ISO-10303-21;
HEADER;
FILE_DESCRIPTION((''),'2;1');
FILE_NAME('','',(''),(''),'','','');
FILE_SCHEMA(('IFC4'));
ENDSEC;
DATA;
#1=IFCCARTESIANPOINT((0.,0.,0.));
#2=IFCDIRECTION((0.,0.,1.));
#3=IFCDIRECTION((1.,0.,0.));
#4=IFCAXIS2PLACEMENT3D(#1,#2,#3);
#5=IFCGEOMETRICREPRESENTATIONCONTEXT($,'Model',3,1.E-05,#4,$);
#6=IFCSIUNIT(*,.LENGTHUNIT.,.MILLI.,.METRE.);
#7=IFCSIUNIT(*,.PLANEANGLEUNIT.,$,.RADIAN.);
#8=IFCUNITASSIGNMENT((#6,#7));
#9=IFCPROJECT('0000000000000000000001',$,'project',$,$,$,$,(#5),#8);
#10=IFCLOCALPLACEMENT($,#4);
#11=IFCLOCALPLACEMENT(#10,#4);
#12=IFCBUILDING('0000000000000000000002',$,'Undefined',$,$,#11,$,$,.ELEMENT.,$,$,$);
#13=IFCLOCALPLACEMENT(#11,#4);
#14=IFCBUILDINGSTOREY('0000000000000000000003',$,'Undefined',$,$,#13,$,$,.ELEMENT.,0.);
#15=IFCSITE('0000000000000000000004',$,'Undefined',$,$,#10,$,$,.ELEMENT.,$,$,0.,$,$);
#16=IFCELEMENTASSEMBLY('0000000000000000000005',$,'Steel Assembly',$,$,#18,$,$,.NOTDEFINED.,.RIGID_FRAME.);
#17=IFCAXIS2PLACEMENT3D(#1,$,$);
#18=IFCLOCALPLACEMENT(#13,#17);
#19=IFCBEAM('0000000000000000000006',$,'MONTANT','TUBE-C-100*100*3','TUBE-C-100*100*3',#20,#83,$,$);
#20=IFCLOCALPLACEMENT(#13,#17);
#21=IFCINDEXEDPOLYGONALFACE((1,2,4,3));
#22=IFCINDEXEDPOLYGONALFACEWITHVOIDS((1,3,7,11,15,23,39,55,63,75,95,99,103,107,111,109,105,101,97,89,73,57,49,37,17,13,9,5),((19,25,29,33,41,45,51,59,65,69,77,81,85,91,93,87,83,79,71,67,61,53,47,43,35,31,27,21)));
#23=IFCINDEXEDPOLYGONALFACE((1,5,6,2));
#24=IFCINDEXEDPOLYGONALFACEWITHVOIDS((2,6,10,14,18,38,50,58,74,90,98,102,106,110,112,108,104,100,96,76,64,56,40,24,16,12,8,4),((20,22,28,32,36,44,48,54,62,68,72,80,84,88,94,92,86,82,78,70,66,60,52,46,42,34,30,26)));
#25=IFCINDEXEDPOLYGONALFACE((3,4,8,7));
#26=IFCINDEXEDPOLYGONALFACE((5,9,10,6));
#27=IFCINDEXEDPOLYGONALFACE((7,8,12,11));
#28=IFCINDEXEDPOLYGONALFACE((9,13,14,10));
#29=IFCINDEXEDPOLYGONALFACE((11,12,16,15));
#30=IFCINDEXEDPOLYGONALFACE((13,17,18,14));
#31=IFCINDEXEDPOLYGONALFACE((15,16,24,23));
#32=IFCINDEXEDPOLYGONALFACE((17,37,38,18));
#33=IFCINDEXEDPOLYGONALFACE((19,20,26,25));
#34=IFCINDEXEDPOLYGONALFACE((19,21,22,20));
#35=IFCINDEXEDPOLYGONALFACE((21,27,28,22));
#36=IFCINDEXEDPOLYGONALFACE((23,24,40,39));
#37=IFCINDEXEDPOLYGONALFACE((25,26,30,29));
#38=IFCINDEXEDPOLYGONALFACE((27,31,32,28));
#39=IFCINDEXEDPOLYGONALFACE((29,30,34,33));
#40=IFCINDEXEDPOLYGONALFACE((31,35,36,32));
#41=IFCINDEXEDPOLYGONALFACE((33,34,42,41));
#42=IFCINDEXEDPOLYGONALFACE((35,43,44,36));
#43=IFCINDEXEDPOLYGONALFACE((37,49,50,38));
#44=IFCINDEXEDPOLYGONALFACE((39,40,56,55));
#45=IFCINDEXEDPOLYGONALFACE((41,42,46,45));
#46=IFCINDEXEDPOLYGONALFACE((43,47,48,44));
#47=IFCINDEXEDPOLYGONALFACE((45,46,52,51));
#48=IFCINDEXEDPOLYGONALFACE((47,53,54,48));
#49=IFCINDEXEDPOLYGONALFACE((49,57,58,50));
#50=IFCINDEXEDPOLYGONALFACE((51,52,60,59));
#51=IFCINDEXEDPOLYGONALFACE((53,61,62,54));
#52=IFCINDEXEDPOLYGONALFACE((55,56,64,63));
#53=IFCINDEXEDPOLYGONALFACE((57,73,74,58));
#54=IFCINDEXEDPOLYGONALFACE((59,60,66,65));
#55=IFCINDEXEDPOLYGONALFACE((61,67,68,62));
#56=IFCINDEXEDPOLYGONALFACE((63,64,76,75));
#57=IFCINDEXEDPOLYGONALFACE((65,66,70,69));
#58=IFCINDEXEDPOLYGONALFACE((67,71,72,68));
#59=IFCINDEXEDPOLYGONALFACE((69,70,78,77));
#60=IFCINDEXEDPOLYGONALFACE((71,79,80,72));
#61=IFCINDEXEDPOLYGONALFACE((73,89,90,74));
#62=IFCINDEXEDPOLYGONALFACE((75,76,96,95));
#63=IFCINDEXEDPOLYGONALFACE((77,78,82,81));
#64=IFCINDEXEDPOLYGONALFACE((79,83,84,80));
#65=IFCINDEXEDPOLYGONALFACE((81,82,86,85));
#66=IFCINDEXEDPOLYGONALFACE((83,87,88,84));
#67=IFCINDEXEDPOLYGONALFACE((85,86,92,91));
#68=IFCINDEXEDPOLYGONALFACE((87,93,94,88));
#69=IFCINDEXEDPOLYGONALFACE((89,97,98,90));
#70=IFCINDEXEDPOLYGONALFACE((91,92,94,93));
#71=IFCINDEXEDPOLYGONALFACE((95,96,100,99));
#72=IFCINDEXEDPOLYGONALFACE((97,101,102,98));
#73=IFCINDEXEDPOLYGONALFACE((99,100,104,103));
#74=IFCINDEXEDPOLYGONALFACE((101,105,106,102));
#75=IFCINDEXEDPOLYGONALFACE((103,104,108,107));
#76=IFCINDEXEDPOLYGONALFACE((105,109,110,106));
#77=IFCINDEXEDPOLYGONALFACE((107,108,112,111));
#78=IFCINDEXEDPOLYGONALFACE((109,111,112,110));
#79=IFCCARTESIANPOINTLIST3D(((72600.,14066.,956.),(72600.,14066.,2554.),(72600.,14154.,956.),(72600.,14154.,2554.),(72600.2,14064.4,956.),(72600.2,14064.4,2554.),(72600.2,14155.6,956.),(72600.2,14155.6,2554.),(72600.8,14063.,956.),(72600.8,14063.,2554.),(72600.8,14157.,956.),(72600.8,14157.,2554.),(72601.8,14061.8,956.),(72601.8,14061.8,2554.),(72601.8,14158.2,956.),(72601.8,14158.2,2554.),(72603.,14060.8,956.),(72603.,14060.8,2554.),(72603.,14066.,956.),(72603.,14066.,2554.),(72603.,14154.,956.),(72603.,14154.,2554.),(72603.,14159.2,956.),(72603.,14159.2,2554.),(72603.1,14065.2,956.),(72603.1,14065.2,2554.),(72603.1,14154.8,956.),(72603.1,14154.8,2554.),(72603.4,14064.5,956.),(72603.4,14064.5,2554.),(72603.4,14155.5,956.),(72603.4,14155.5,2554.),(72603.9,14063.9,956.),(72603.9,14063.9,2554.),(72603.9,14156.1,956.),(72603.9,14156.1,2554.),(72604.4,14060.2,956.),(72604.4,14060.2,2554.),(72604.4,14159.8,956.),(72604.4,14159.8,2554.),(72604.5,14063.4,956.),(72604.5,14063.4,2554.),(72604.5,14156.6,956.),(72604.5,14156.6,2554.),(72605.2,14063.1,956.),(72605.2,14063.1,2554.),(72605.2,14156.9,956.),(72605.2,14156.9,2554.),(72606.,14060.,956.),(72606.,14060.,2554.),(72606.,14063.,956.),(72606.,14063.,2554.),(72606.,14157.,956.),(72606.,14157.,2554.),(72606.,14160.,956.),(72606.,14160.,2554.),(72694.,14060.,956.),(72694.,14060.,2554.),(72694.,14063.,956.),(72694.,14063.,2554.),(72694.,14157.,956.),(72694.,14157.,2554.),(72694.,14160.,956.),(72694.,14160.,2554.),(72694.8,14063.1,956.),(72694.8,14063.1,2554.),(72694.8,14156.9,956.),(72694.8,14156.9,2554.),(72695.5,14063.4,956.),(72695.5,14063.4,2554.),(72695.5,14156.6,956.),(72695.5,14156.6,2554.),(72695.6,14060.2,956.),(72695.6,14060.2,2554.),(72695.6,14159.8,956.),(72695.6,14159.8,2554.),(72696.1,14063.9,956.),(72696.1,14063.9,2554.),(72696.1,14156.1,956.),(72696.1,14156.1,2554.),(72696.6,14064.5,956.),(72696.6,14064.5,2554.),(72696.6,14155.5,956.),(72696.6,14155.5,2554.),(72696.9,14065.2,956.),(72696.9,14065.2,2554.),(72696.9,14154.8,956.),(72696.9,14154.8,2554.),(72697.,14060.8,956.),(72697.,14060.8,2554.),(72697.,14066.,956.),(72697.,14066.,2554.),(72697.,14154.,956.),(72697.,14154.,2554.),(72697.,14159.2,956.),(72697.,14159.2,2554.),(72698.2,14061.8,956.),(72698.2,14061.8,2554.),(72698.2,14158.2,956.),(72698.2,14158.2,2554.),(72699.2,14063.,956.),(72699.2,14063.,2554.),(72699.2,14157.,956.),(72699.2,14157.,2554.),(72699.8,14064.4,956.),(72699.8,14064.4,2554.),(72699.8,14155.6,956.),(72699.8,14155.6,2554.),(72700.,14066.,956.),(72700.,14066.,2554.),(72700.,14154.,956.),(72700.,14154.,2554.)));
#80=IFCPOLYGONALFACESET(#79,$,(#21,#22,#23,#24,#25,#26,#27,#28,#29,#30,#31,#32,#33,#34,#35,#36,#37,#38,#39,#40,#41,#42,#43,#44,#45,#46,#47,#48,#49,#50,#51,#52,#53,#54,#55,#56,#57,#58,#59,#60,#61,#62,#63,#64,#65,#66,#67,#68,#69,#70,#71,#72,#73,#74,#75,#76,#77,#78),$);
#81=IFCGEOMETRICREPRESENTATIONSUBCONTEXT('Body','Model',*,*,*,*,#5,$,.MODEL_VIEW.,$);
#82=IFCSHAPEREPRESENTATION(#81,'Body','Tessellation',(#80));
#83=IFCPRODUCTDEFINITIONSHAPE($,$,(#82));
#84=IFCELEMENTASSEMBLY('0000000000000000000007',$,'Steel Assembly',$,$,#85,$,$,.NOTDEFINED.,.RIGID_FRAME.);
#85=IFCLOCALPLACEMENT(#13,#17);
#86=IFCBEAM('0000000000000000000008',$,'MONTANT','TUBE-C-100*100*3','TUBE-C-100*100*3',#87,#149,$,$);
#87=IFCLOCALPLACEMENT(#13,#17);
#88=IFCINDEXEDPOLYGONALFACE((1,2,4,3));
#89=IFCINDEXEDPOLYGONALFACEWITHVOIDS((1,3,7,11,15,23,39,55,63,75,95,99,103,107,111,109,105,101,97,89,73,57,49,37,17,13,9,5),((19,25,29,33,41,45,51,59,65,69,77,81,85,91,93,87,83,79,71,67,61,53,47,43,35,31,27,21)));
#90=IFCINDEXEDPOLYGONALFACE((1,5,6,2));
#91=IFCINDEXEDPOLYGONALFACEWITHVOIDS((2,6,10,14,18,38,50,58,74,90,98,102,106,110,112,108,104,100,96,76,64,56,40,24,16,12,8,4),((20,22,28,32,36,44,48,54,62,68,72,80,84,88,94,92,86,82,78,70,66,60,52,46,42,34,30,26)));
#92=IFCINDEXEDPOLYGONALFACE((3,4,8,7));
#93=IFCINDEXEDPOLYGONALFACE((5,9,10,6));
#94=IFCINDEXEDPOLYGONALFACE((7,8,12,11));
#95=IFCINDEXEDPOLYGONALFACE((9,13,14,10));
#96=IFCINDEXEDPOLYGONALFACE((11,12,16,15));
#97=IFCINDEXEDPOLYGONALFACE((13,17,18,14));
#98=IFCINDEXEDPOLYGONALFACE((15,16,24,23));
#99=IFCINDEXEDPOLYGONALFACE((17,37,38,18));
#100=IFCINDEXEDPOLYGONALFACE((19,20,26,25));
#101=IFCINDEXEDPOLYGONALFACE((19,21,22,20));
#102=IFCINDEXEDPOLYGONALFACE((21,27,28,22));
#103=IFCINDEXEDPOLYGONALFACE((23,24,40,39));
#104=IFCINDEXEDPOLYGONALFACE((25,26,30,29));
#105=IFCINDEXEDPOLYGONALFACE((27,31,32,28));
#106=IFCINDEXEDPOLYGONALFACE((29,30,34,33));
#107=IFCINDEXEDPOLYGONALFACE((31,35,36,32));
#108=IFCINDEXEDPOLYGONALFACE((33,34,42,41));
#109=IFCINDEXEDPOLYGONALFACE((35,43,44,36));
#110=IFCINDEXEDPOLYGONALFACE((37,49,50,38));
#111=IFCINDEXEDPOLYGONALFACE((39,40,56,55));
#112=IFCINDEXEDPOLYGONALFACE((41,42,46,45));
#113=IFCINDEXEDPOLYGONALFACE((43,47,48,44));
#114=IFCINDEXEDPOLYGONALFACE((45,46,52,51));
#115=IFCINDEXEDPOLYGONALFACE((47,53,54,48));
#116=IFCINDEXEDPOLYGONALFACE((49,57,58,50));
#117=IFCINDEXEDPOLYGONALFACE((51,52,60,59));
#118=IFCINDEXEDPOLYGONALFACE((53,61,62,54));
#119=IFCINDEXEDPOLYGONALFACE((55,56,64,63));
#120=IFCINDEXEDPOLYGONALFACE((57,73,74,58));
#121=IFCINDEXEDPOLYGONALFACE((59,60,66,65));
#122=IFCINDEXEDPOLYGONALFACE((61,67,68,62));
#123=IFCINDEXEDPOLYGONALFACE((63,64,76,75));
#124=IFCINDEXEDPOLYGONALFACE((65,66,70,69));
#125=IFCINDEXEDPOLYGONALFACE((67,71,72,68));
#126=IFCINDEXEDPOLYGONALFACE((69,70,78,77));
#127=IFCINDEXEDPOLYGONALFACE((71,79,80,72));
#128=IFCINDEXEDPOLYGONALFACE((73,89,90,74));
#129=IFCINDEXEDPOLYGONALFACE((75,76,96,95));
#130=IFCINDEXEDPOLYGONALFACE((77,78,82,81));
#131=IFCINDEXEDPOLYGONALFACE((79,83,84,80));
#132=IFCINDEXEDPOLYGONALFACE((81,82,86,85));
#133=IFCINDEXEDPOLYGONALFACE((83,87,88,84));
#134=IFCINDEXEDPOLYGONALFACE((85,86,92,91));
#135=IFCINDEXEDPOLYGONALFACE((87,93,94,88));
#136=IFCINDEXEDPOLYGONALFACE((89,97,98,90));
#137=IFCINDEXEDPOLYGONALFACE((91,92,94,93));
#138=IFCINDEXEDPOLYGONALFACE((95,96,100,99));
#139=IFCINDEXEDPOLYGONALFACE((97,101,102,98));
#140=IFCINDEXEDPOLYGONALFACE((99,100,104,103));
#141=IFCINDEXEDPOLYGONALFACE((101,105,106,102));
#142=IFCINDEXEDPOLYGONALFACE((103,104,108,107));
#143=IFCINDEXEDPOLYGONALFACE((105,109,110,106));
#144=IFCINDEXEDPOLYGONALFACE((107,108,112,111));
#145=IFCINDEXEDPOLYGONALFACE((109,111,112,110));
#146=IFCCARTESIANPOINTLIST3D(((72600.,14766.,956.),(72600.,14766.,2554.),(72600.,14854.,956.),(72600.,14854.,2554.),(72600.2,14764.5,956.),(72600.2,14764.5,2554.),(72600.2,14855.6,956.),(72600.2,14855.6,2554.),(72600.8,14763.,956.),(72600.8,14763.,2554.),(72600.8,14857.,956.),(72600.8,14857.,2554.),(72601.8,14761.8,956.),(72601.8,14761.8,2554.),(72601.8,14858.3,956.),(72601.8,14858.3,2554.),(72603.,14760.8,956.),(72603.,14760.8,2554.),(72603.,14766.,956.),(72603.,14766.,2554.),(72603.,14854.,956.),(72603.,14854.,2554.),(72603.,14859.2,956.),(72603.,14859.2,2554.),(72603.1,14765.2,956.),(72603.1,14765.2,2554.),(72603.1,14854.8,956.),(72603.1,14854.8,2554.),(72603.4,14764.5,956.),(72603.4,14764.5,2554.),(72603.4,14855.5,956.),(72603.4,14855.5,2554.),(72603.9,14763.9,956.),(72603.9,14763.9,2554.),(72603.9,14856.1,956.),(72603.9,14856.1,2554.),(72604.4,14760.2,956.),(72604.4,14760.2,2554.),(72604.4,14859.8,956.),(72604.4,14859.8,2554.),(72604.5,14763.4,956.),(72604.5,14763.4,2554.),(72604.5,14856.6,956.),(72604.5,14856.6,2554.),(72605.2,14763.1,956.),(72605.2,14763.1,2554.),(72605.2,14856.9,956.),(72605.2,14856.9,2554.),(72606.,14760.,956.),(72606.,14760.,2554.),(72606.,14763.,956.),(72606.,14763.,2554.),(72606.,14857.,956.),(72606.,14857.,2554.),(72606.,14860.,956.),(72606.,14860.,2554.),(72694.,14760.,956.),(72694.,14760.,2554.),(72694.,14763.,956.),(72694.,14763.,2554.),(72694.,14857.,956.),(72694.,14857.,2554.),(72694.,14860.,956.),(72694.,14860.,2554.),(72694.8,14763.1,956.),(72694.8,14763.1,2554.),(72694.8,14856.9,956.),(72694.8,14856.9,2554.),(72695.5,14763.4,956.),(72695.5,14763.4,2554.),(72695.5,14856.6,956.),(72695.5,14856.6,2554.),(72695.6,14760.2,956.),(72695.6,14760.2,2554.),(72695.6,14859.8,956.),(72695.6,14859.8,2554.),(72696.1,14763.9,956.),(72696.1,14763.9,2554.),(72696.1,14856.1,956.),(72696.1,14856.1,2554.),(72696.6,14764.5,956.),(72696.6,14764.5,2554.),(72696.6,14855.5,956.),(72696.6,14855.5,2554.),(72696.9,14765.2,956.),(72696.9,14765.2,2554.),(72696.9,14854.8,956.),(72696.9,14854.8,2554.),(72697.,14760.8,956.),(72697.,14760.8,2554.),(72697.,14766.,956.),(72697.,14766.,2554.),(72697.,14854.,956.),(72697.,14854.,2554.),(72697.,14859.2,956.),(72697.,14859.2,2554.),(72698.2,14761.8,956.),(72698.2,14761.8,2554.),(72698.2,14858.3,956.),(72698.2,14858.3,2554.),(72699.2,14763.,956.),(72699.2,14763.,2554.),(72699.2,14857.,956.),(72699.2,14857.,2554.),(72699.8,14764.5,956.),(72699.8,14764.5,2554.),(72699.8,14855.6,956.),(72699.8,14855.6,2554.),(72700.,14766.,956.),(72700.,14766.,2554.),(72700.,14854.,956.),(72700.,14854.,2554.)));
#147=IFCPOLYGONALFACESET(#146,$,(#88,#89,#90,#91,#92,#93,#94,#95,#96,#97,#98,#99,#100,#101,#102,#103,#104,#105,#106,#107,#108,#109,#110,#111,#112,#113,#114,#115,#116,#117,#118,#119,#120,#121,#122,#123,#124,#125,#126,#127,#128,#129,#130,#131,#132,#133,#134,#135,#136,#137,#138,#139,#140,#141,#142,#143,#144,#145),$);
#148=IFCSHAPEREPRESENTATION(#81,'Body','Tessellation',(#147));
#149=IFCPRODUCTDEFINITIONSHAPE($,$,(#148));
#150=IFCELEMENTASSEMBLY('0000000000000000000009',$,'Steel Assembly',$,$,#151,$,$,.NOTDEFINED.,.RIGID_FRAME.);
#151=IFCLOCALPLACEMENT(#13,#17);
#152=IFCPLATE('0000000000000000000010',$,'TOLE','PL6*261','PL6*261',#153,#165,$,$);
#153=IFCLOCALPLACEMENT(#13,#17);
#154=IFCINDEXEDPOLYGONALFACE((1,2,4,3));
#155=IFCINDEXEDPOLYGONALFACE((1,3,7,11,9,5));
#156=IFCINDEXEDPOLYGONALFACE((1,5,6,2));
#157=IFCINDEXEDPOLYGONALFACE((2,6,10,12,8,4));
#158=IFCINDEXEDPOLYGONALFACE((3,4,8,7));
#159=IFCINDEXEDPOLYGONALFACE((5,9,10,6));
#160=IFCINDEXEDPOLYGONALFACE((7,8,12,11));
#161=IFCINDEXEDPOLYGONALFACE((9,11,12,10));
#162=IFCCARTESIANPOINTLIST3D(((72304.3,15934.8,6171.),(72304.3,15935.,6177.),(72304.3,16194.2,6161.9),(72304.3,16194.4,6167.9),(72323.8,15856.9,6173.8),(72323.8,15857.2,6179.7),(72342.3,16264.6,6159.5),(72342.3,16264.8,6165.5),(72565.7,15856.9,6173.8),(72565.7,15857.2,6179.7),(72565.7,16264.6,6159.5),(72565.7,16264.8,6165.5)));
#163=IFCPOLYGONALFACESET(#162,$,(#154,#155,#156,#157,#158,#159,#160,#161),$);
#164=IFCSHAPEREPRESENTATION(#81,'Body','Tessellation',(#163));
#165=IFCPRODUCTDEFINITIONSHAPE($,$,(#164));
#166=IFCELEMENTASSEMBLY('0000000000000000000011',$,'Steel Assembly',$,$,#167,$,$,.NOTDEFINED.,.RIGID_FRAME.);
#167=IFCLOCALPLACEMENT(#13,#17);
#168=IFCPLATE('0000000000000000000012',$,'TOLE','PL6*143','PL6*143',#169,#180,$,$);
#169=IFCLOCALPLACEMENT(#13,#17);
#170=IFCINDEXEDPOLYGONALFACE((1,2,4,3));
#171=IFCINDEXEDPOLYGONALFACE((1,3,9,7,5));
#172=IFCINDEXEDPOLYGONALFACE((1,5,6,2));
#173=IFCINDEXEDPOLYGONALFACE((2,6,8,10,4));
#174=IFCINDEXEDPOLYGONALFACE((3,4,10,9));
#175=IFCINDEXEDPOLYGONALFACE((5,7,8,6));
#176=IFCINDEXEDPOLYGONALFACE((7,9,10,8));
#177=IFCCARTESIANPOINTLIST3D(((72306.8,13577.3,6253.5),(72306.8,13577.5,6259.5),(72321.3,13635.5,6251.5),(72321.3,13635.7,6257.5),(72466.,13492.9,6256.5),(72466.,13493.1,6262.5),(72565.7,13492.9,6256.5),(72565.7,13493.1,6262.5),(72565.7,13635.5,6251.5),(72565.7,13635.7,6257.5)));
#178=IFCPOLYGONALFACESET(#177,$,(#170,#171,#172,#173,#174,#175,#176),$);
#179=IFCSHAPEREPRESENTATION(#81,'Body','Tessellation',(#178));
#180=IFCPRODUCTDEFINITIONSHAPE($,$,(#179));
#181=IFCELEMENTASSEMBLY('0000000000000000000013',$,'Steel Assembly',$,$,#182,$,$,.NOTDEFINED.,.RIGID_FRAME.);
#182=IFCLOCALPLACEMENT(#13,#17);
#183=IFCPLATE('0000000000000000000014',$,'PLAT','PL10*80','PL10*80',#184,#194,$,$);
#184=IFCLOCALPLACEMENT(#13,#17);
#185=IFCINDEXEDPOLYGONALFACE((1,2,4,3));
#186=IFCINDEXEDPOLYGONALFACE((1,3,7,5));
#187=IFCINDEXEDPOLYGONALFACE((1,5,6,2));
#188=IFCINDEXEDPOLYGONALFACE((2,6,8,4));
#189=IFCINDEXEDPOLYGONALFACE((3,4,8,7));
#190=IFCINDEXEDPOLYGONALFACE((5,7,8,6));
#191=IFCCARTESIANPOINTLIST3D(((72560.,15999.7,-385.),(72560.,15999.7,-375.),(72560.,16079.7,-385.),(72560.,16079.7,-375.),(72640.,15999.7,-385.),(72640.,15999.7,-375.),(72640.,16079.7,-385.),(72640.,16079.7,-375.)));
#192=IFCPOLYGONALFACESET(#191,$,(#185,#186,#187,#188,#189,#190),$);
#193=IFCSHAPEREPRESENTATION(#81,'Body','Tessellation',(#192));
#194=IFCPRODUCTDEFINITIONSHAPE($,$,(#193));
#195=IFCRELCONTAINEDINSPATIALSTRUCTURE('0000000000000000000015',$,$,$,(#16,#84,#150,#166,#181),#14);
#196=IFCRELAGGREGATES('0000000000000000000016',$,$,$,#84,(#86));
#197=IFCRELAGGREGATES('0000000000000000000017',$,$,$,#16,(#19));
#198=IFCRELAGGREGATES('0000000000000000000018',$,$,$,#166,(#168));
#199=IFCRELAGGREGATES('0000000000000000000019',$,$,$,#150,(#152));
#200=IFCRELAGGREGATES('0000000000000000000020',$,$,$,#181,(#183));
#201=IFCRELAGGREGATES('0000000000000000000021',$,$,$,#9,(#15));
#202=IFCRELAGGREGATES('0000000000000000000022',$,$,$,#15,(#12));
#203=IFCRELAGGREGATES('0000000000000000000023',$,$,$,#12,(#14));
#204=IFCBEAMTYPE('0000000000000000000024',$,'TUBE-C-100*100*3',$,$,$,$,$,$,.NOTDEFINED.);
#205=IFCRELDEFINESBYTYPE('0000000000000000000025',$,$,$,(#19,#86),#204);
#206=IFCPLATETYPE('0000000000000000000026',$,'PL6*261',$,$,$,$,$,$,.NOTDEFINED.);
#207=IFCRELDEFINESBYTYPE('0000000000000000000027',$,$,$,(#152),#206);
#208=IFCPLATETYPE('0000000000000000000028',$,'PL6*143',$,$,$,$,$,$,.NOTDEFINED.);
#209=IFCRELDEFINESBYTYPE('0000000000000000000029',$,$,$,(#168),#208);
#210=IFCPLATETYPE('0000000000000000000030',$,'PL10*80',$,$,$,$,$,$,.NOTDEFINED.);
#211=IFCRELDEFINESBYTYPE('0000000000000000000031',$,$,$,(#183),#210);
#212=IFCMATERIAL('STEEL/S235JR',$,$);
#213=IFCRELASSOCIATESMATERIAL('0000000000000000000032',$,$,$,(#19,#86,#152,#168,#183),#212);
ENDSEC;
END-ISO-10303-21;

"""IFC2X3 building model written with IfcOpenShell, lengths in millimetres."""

from ifc_helpers import new_model, si_unit, frame, origin_with_axes, origin_2d_with_axis, place, context, subcontext, project, spatial, polyline, hollow_rectangle, outline, extrude, clip, halfspace, material, type_object, element, aggregate, save


model = new_model("IFC2X3")

# Units and contexts
model_context = context("Model", 3, precision=1e-05, world=origin_with_axes())
body_context = subcontext(model_context, "Body", "Model", "MODEL_VIEW")
ifc_project = project(units=[si_unit("LENGTHUNIT", "METRE", prefix="MILLI"), si_unit("PLANEANGLEUNIT", "RADIAN")], contexts=[model_context])

# Site, building, storey
site_placement = place(None, origin_with_axes())
site = spatial("IfcSite", under=ifc_project, at=site_placement, Name="Undefined", CompositionType="ELEMENT", RefElevation=0.0)
building_placement = place(site_placement, origin_with_axes())
building = spatial("IfcBuilding", under=site, at=building_placement, Name="Undefined", CompositionType="ELEMENT")
storey_placement = place(building_placement, origin_with_axes())
storey = spatial("IfcBuildingStorey", under=building, at=storey_placement, Name="Undefined", CompositionType="ELEMENT", Elevation=0.0)

# Shared definitions
ifc_material_1 = material(Name="STEEL/S235JR")

# Element assemblies, beams
beam_type_1 = type_object("IfcBeamType", Name="TUBE-C-100*100*3", PredefinedType="NOTDEFINED")
assembly_1_placement = place(storey_placement, origin_with_axes())
assembly_1 = element("IfcElementAssembly", 1, at=assembly_1_placement, inside=storey, Name="Steel Assembly", AssemblyPlace="NOTDEFINED", PredefinedType="RIGID_FRAME")
beam_1_placement = place(assembly_1_placement, frame((72650.0, 14110.0, 2560.0), z_axis=(0.0, -1.0, 0.0), x_axis=(0.0, 0.0, -1.0)))
beam_1 = element("IfcBeam", 2, at=beam_1_placement, type_object=beam_type_1, material=ifc_material_1, Name="MONTANT", Description="TUBE-C-100*100*3", ObjectType="TUBE-C-100*100*3", context=body_context, shape_type="Clipping", body=[
    clip(clip(extrude(hollow_rectangle(XDim=100.0, YDim=100.0, WallThickness=3.0, InnerFilletRadius=3.0, OuterFilletRadius=6.0, at=origin_2d_with_axis()), frame((1610.0, 0.0, 0.0), z_axis=(-1.0, 0.0, 0.0), x_axis=(0.0, -1.0, 0.0)), (0.0, 0.0, 1.0), 1610.0), halfspace(frame((1604.0, -50.0, 50.0), z_axis=(1.0, 0.0, 0.0), x_axis=(0.0, 1.0, 0.0)), False)), halfspace(frame((6.0, 50.0, 50.0), z_axis=(-1.0, 0.0, 0.0), x_axis=(0.0, -1.0, 0.0)), False)),
])
assembly_2_placement = place(storey_placement, origin_with_axes())
assembly_2 = element("IfcElementAssembly", 3, at=assembly_2_placement, inside=storey, Name="Steel Assembly", AssemblyPlace="NOTDEFINED", PredefinedType="RIGID_FRAME")
beam_2_placement = place(assembly_2_placement, frame((72650.0, 14810.0, 2560.0), z_axis=(0.0, 1.0, 0.0), x_axis=(0.0, 0.0, -1.0)))
beam_2 = element("IfcBeam", 4, at=beam_2_placement, type_object=beam_type_1, material=ifc_material_1, Name="MONTANT", Description="TUBE-C-100*100*3", ObjectType="TUBE-C-100*100*3", context=body_context, shape_type="Clipping", body=[
    clip(clip(extrude(hollow_rectangle(XDim=100.0, YDim=100.0, WallThickness=3.0, InnerFilletRadius=3.0, OuterFilletRadius=6.0, at=origin_2d_with_axis()), frame((1610.0, 0.0, 0.0), z_axis=(-1.0, 0.0, 0.0), x_axis=(0.0, -1.0, 0.0)), (0.0, 0.0, 1.0), 1610.0), halfspace(frame((1604.0, -50.0, 50.0), z_axis=(1.0, 0.0, 0.0), x_axis=(0.0, 1.0, 0.0)), False)), halfspace(frame((6.0, 50.0, 50.0), z_axis=(-1.0, 0.0, 0.0), x_axis=(0.0, -1.0, 0.0)), False)),
])

# Element assemblies, plates
assembly_3_placement = place(storey_placement, origin_with_axes())
assembly_3 = element("IfcElementAssembly", 5, at=assembly_3_placement, inside=storey, Name="Steel Assembly", AssemblyPlace="NOTDEFINED", PredefinedType="RIGID_FRAME")
plate_type_1 = type_object("IfcPlateType", Name="PL6*261", PredefinedType="NOTDEFINED")
plate_1_placement = place(assembly_3_placement, frame((72565.7, 15857.0, 6176.8), z_axis=(0.0, 0.034979, 0.999388), x_axis=(0.0, 0.999388, -0.034978)))
plate_1 = element("IfcPlate", 6, at=plate_1_placement, type_object=plate_type_1, material=ifc_material_1, Name="TOLE", Description="PL6*261", ObjectType="PL6*261", context=body_context, shape_type="SweptSolid", body=[
    extrude(outline(polyline([(0.0, 0.0), (407.9, 0.0), (407.9, 223.4), (337.5, 261.4), (77.9, 261.4), (0.0, 242.0), (0.0, 0.0)])), frame((0.0, 0.0, -3.0), z_axis=(0.0, 0.0, 1.0), x_axis=(1.0, 0.0, 0.0)), (0.0, 0.0, 1.0), 6.0),
])
assembly_4_placement = place(storey_placement, origin_with_axes())
assembly_4 = element("IfcElementAssembly", 7, at=assembly_4_placement, inside=storey, Name="Steel Assembly", AssemblyPlace="NOTDEFINED", PredefinedType="RIGID_FRAME")
plate_type_2 = type_object("IfcPlateType", Name="PL6*143", PredefinedType="NOTDEFINED")
plate_2_placement = place(assembly_4_placement, frame((72565.7, 13493.0, 6259.5), z_axis=(0.0, 0.034979, 0.999388), x_axis=(0.0, 0.999388, -0.034978)))
plate_2 = element("IfcPlate", 8, at=plate_2_placement, type_object=plate_type_2, material=ifc_material_1, Name="TOLE", Description="PL6*143", ObjectType="PL6*143", context=body_context, shape_type="SweptSolid", body=[
    extrude(outline(polyline([(0.0, 0.0), (142.7, 0.0), (142.7, 244.4), (84.5, 258.9), (0.0, 99.7), (0.0, 0.0)])), frame((0.0, 0.0, -3.0), z_axis=(0.0, 0.0, 1.0), x_axis=(1.0, 0.0, 0.0)), (0.0, 0.0, 1.0), 6.0),
])
assembly_5_placement = place(storey_placement, origin_with_axes())
assembly_5 = element("IfcElementAssembly", 9, at=assembly_5_placement, inside=storey, Name="Steel Assembly", AssemblyPlace="NOTDEFINED", PredefinedType="RIGID_FRAME")
plate_type_3 = type_object("IfcPlateType", Name="PL10*80", PredefinedType="NOTDEFINED")
plate_3_placement = place(assembly_5_placement, frame((72640.0, 15999.7, -380.0), z_axis=(0.0, 0.0, -1.0), x_axis=(-1.0, 0.0, 0.0)))
plate_3 = element("IfcPlate", 10, at=plate_3_placement, type_object=plate_type_3, material=ifc_material_1, Name="PLAT", Description="PL10*80", ObjectType="PL10*80", context=body_context, shape_type="SweptSolid", body=[
    extrude(outline(polyline([(0.0, 0.0), (80.0, 0.0), (80.0, 80.0), (0.0, 80.0), (0.0, 0.0)])), frame((0.0, 0.0, -5.0), z_axis=(0.0, 0.0, 1.0), x_axis=(1.0, 0.0, 0.0)), (0.0, 0.0, 1.0), 10.0),
])

aggregate(assembly_2, [beam_2])
aggregate(assembly_1, [beam_1])

aggregate(assembly_4, [plate_2])
aggregate(assembly_3, [plate_1])
aggregate(assembly_5, [plate_3])

save(model, "model.ifc")
